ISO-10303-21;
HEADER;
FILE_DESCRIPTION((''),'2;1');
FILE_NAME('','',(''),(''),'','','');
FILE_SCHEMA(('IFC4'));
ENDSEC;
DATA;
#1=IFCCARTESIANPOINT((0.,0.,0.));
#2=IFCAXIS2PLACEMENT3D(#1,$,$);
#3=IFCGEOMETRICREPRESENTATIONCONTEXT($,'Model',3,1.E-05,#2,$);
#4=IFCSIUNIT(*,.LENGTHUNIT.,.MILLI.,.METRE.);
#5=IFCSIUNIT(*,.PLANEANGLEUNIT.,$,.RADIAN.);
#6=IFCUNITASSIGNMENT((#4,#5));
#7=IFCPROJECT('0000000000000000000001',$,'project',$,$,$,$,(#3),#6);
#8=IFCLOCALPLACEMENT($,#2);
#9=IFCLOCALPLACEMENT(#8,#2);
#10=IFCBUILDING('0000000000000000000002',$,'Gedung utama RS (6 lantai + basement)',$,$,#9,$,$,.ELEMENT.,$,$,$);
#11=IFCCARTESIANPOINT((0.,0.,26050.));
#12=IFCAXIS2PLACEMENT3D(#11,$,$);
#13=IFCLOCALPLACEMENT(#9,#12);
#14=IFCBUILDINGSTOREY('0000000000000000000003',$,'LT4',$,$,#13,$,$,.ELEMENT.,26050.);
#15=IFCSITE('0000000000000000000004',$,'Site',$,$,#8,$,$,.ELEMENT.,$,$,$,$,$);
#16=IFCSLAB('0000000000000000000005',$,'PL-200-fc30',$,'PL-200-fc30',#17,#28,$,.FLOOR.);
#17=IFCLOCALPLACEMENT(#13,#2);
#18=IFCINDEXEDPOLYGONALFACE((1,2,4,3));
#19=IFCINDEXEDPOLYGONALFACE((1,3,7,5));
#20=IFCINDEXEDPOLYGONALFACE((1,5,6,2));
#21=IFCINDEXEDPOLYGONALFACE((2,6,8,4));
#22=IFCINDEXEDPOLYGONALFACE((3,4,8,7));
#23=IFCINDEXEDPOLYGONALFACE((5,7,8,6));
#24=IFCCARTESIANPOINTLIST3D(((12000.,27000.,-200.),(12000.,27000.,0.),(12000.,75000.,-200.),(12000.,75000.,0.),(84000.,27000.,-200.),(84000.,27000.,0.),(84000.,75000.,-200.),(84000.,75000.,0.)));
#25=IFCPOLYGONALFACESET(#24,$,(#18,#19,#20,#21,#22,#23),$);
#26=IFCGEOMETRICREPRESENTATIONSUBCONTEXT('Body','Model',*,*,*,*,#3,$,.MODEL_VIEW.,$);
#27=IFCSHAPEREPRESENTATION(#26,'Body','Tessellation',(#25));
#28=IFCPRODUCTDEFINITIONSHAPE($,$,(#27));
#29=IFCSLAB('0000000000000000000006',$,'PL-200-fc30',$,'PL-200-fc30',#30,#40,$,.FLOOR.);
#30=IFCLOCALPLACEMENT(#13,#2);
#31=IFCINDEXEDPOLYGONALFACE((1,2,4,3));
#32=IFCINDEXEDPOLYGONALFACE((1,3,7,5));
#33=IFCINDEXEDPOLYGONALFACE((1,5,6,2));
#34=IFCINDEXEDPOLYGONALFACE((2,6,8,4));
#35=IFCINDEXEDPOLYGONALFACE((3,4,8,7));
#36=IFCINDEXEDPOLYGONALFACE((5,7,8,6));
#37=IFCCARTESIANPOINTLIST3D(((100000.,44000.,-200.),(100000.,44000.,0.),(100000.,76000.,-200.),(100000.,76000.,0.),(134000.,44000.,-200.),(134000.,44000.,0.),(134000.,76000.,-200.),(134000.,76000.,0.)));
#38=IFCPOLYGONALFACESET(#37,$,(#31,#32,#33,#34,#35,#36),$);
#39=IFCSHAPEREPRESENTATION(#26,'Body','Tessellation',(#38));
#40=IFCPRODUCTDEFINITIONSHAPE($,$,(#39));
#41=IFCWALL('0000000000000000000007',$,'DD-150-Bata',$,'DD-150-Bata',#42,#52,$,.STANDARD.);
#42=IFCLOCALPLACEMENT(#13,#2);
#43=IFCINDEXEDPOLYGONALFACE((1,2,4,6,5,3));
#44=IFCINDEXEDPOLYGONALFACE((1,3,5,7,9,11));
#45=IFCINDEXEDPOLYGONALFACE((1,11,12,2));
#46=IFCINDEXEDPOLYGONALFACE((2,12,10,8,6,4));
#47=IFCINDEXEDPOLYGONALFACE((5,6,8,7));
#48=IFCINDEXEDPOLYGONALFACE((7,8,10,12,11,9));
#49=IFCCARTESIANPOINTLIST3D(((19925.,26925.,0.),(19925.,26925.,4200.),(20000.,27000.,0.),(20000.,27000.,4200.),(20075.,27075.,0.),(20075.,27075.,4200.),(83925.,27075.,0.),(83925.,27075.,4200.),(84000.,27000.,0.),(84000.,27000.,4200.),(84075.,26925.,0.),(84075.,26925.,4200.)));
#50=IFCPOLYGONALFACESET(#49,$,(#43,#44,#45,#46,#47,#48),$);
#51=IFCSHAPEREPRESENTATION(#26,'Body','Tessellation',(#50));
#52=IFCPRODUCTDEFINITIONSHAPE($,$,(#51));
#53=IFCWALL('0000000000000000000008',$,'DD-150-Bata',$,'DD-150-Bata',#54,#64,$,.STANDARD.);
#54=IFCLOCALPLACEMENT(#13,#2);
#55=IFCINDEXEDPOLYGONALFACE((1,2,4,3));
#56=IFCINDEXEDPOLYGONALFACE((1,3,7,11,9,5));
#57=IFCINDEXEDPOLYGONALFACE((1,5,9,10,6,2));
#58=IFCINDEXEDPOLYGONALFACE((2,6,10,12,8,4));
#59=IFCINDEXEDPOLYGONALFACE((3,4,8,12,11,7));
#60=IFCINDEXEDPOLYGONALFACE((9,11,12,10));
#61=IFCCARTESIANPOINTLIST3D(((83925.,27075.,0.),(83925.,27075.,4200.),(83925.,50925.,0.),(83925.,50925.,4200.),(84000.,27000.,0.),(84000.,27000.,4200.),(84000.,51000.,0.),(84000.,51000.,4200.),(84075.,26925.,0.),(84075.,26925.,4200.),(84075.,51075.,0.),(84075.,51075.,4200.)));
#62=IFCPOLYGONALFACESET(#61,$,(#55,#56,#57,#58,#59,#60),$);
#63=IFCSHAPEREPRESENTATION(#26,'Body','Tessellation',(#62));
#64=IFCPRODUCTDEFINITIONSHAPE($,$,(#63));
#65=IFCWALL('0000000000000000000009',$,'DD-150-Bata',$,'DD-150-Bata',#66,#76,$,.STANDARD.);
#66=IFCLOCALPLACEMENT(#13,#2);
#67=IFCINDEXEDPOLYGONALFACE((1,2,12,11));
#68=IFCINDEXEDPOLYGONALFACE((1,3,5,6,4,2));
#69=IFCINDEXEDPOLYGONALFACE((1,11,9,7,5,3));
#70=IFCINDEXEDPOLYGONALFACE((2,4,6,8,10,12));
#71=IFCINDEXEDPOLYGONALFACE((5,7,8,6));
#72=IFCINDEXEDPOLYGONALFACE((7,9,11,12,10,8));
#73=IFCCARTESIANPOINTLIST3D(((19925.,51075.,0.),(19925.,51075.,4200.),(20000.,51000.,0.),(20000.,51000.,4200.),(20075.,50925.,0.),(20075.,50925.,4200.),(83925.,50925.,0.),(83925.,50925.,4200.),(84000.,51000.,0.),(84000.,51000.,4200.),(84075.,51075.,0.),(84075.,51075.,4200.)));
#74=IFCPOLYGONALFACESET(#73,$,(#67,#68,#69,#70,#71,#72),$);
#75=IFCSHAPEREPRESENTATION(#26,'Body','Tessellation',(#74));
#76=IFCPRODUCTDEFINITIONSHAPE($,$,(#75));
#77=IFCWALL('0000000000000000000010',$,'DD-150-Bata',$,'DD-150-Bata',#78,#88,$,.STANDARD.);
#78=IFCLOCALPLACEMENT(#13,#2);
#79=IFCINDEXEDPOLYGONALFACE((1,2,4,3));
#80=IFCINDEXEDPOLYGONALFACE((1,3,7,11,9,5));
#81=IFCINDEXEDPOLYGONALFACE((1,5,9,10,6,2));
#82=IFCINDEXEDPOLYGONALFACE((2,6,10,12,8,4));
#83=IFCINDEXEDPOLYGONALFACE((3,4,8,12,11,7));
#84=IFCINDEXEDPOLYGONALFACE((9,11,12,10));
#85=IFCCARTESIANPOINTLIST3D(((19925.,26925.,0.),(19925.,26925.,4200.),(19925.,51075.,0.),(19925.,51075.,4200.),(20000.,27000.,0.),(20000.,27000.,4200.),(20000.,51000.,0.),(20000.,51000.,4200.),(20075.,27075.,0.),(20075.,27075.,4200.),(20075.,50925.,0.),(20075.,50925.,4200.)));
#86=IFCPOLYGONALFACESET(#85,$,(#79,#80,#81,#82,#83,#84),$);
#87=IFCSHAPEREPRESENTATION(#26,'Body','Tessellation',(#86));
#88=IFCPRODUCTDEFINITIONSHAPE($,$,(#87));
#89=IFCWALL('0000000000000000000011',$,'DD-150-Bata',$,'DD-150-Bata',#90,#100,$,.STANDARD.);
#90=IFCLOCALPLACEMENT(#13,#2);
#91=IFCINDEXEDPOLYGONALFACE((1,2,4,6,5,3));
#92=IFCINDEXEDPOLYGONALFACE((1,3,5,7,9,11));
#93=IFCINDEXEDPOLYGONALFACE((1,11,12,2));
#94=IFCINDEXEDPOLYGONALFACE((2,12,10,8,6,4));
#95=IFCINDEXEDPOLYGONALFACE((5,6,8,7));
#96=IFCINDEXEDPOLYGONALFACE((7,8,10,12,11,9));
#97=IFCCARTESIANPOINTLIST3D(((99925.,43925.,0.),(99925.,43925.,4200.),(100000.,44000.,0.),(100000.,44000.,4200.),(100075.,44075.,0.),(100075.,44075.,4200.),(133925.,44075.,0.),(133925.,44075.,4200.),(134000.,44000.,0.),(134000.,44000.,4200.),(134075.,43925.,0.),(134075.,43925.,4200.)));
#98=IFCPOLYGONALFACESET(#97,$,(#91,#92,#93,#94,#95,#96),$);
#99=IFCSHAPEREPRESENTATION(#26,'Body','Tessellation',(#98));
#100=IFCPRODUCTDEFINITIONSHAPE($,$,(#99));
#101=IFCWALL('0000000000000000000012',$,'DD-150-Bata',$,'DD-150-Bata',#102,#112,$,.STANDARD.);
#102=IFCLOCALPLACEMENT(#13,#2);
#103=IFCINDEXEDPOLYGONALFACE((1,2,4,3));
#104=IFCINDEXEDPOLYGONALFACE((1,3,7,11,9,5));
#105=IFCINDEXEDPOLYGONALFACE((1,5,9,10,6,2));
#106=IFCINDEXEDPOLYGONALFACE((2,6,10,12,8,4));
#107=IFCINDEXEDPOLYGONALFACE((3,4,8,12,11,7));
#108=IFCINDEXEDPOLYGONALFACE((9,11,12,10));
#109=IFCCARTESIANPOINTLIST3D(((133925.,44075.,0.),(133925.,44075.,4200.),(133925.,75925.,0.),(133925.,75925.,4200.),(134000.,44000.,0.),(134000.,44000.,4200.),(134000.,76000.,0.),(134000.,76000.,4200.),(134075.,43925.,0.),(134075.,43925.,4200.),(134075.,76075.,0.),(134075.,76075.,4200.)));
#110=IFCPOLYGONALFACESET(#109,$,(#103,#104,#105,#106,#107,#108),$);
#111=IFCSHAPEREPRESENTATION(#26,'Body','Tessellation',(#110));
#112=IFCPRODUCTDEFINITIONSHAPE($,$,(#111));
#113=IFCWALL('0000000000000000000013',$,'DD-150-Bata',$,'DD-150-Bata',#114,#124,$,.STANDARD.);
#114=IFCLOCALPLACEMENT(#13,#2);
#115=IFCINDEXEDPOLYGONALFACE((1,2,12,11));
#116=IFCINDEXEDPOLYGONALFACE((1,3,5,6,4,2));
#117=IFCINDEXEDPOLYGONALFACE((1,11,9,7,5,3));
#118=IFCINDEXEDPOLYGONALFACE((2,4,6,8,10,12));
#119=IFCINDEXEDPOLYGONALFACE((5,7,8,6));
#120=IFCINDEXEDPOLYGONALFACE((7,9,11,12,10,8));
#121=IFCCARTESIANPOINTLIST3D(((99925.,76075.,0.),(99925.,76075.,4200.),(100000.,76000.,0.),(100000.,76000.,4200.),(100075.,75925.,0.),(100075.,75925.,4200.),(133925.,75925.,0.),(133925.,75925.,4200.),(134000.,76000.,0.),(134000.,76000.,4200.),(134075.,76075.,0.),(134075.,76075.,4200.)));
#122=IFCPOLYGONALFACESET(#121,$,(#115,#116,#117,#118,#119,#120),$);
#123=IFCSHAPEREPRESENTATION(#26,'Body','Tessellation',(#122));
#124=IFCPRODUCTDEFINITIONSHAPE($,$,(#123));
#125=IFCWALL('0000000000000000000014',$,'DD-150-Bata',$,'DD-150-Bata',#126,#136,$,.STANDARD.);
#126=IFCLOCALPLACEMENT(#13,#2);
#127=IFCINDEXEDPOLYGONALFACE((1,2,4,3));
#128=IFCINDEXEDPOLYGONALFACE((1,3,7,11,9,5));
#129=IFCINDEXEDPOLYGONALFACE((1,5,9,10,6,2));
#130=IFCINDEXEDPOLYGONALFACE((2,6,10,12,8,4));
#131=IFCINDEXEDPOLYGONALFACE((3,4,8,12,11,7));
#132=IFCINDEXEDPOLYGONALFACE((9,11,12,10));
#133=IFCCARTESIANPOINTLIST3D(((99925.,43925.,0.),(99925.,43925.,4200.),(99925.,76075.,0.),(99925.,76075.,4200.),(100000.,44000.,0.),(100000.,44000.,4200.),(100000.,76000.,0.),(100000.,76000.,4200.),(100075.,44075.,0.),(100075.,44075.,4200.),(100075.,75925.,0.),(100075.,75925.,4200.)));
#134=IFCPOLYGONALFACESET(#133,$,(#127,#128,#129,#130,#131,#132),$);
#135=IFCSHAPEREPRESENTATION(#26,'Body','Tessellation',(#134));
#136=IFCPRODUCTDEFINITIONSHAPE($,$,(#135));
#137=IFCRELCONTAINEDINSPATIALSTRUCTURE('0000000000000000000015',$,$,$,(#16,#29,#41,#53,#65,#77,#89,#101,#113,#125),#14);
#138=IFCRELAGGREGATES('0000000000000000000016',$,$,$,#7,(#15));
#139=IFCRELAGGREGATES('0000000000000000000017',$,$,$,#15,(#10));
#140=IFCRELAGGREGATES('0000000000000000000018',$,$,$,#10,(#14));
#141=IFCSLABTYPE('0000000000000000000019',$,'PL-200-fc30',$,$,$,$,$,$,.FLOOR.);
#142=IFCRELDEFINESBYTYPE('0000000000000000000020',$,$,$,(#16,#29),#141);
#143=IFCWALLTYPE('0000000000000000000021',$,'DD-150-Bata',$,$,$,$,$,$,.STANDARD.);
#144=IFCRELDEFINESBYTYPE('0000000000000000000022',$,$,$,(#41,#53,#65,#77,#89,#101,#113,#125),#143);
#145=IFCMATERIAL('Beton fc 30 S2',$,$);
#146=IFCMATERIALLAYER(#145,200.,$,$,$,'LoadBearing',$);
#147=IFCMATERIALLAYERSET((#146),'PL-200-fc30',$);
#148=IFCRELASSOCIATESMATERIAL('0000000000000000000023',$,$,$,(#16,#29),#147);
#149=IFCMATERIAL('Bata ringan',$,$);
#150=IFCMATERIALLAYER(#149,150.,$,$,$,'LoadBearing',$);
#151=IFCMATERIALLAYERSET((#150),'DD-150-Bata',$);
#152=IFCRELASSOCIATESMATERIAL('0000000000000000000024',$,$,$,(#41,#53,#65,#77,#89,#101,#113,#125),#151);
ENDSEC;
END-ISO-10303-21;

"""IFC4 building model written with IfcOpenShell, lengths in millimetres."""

from ifc_helpers import new_model, si_unit, frame, origin, place, context, subcontext, project, spatial, polyline, outline, extrude, material, layer, layer_set, layer_usage, type_object, element, save


model = new_model("IFC4")

# Units and contexts
model_context = context("Model", 3, precision=1e-05, world=origin())
body_context = subcontext(model_context, "Body", "Model", "MODEL_VIEW")
ifc_project = project(units=[si_unit("LENGTHUNIT", "METRE", prefix="MILLI"), si_unit("PLANEANGLEUNIT", "RADIAN")], contexts=[model_context])

# Site, building, storey
site_placement = place(None, origin())
site = spatial("IfcSite", under=ifc_project, at=site_placement, Name="Site", CompositionType="ELEMENT")
building_placement = place(site_placement, origin())
building = spatial("IfcBuilding", under=site, at=building_placement, Name="Gedung utama RS (6 lantai + basement)", CompositionType="ELEMENT")
storey_placement = place(building_placement, frame((0.0, 0.0, 26050.0)))
storey = spatial("IfcBuildingStorey", under=building, at=storey_placement, Name="LT4", CompositionType="ELEMENT", Elevation=26050.0)

# Slabs
ifc_material_1 = material(Name="Beton fc 30 S2")
ifc_layer_1 = layer(ifc_material_1, 200.0, Category="LoadBearing")
ifc_layer_set_1 = layer_set([ifc_layer_1], Name="PL-200-fc30")
ifc_layer_usage_1 = layer_usage(ifc_layer_set_1, "AXIS3", "NEGATIVE", 0.0)
slab_type = type_object("IfcSlabType", Name="PL-200-fc30", PredefinedType="FLOOR")
slab_1_placement = place(storey_placement, origin())
element("IfcSlab", 1, at=slab_1_placement, inside=storey, type_object=slab_type, material=ifc_layer_usage_1, Name="PL-200-fc30", ObjectType="PL-200-fc30", PredefinedType="FLOOR", context=body_context, shape_type="SweptSolid", body=[
    extrude(outline(polyline([(12000.0, 27000.0), (84000.0, 27000.0), (84000.0, 75000.0), (12000.0, 75000.0), (12000.0, 27000.0)])), frame((0.0, 0.0, -200.0)), (0.0, 0.0, 1.0), 200.0),
])
slab_2_placement = place(storey_placement, origin())
element("IfcSlab", 2, at=slab_2_placement, inside=storey, type_object=slab_type, material=ifc_layer_usage_1, Name="PL-200-fc30", ObjectType="PL-200-fc30", PredefinedType="FLOOR", context=body_context, shape_type="SweptSolid", body=[
    extrude(outline(polyline([(100000.0, 44000.0), (134000.0, 44000.0), (134000.0, 76000.0), (100000.0, 76000.0), (100000.0, 44000.0)])), frame((0.0, 0.0, -200.0)), (0.0, 0.0, 1.0), 200.0),
])

# Walls
ifc_material_2 = material(Name="Bata ringan")
ifc_layer_2 = layer(ifc_material_2, 150.0, Category="LoadBearing")
ifc_layer_set_2 = layer_set([ifc_layer_2], Name="DD-150-Bata")
ifc_layer_usage_2 = layer_usage(ifc_layer_set_2, "AXIS2", "NEGATIVE", 75.0)
wall_type = type_object("IfcWallType", Name="DD-150-Bata", PredefinedType="STANDARD")
wall_1_placement = place(storey_placement, frame((20000.0, 27000.0, 0.0), z_axis=(0.0, 0.0, 1.0), x_axis=(1.0, 0.0, 0.0)))
element("IfcWall", 3, at=wall_1_placement, inside=storey, type_object=wall_type, material=ifc_layer_usage_2, Name="DD-150-Bata", ObjectType="DD-150-Bata", PredefinedType="STANDARD", context=body_context, shape_type="SweptSolid", body=[
    extrude(outline(polyline([(-75.0, -75.0), (0.0, 0.0), (75.0, 75.0), (63925.0, 75.0), (64000.0, 0.0), (64075.0, -75.0), (-75.0, -75.0)])), origin(), (0.0, 0.0, 1.0), 4200.0),
])
wall_2_placement = place(storey_placement, frame((84000.0, 27000.0, 0.0), z_axis=(0.0, 0.0, 1.0), x_axis=(0.0, 1.0, 0.0)))
element("IfcWall", 4, at=wall_2_placement, inside=storey, type_object=wall_type, material=ifc_layer_usage_2, Name="DD-150-Bata", ObjectType="DD-150-Bata", PredefinedType="STANDARD", context=body_context, shape_type="SweptSolid", body=[
    extrude(outline(polyline([(-75.0, -75.0), (0.0, 0.0), (75.0, 75.0), (23925.0, 75.0), (24000.0, 0.0), (24075.0, -75.0), (-75.0, -75.0)])), origin(), (0.0, 0.0, 1.0), 4200.0),
])
wall_3_placement = place(storey_placement, frame((84000.0, 51000.0, 0.0), z_axis=(0.0, 0.0, 1.0), x_axis=(-1.0, 0.0, 0.0)))
element("IfcWall", 5, at=wall_3_placement, inside=storey, type_object=wall_type, material=ifc_layer_usage_2, Name="DD-150-Bata", ObjectType="DD-150-Bata", PredefinedType="STANDARD", context=body_context, shape_type="SweptSolid", body=[
    extrude(outline(polyline([(-75.0, -75.0), (0.0, 0.0), (75.0, 75.0), (63925.0, 75.0), (64000.0, 0.0), (64075.0, -75.0), (-75.0, -75.0)])), origin(), (0.0, 0.0, 1.0), 4200.0),
])
wall_4_placement = place(storey_placement, frame((20000.0, 51000.0, 0.0), z_axis=(0.0, 0.0, 1.0), x_axis=(0.0, -1.0, 0.0)))
element("IfcWall", 6, at=wall_4_placement, inside=storey, type_object=wall_type, material=ifc_layer_usage_2, Name="DD-150-Bata", ObjectType="DD-150-Bata", PredefinedType="STANDARD", context=body_context, shape_type="SweptSolid", body=[
    extrude(outline(polyline([(-75.0, -75.0), (0.0, 0.0), (75.0, 75.0), (23925.0, 75.0), (24000.0, 0.0), (24075.0, -75.0), (-75.0, -75.0)])), origin(), (0.0, 0.0, 1.0), 4200.0),
])
wall_5_placement = place(storey_placement, frame((100000.0, 44000.0, 0.0), z_axis=(0.0, 0.0, 1.0), x_axis=(1.0, 0.0, 0.0)))
element("IfcWall", 7, at=wall_5_placement, inside=storey, type_object=wall_type, material=ifc_layer_usage_2, Name="DD-150-Bata", ObjectType="DD-150-Bata", PredefinedType="STANDARD", context=body_context, shape_type="SweptSolid", body=[
    extrude(outline(polyline([(-75.0, -75.0), (0.0, 0.0), (75.0, 75.0), (33925.0, 75.0), (34000.0, 0.0), (34075.0, -75.0), (-75.0, -75.0)])), origin(), (0.0, 0.0, 1.0), 4200.0),
])
wall_6_placement = place(storey_placement, frame((134000.0, 44000.0, 0.0), z_axis=(0.0, 0.0, 1.0), x_axis=(0.0, 1.0, 0.0)))
element("IfcWall", 8, at=wall_6_placement, inside=storey, type_object=wall_type, material=ifc_layer_usage_2, Name="DD-150-Bata", ObjectType="DD-150-Bata", PredefinedType="STANDARD", context=body_context, shape_type="SweptSolid", body=[
    extrude(outline(polyline([(-75.0, -75.0), (0.0, 0.0), (75.0, 75.0), (31925.0, 75.0), (32000.0, 0.0), (32075.0, -75.0), (-75.0, -75.0)])), origin(), (0.0, 0.0, 1.0), 4200.0),
])
wall_7_placement = place(storey_placement, frame((134000.0, 76000.0, 0.0), z_axis=(0.0, 0.0, 1.0), x_axis=(-1.0, 0.0, 0.0)))
element("IfcWall", 9, at=wall_7_placement, inside=storey, type_object=wall_type, material=ifc_layer_usage_2, Name="DD-150-Bata", ObjectType="DD-150-Bata", PredefinedType="STANDARD", context=body_context, shape_type="SweptSolid", body=[
    extrude(outline(polyline([(-75.0, -75.0), (0.0, 0.0), (75.0, 75.0), (33925.0, 75.0), (34000.0, 0.0), (34075.0, -75.0), (-75.0, -75.0)])), origin(), (0.0, 0.0, 1.0), 4200.0),
])
wall_8_placement = place(storey_placement, frame((100000.0, 76000.0, 0.0), z_axis=(0.0, 0.0, 1.0), x_axis=(0.0, -1.0, 0.0)))
element("IfcWall", 10, at=wall_8_placement, inside=storey, type_object=wall_type, material=ifc_layer_usage_2, Name="DD-150-Bata", ObjectType="DD-150-Bata", PredefinedType="STANDARD", context=body_context, shape_type="SweptSolid", body=[
    extrude(outline(polyline([(-75.0, -75.0), (0.0, 0.0), (75.0, 75.0), (31925.0, 75.0), (32000.0, 0.0), (32075.0, -75.0), (-75.0, -75.0)])), origin(), (0.0, 0.0, 1.0), 4200.0),
])

save(model, "model.ifc")
